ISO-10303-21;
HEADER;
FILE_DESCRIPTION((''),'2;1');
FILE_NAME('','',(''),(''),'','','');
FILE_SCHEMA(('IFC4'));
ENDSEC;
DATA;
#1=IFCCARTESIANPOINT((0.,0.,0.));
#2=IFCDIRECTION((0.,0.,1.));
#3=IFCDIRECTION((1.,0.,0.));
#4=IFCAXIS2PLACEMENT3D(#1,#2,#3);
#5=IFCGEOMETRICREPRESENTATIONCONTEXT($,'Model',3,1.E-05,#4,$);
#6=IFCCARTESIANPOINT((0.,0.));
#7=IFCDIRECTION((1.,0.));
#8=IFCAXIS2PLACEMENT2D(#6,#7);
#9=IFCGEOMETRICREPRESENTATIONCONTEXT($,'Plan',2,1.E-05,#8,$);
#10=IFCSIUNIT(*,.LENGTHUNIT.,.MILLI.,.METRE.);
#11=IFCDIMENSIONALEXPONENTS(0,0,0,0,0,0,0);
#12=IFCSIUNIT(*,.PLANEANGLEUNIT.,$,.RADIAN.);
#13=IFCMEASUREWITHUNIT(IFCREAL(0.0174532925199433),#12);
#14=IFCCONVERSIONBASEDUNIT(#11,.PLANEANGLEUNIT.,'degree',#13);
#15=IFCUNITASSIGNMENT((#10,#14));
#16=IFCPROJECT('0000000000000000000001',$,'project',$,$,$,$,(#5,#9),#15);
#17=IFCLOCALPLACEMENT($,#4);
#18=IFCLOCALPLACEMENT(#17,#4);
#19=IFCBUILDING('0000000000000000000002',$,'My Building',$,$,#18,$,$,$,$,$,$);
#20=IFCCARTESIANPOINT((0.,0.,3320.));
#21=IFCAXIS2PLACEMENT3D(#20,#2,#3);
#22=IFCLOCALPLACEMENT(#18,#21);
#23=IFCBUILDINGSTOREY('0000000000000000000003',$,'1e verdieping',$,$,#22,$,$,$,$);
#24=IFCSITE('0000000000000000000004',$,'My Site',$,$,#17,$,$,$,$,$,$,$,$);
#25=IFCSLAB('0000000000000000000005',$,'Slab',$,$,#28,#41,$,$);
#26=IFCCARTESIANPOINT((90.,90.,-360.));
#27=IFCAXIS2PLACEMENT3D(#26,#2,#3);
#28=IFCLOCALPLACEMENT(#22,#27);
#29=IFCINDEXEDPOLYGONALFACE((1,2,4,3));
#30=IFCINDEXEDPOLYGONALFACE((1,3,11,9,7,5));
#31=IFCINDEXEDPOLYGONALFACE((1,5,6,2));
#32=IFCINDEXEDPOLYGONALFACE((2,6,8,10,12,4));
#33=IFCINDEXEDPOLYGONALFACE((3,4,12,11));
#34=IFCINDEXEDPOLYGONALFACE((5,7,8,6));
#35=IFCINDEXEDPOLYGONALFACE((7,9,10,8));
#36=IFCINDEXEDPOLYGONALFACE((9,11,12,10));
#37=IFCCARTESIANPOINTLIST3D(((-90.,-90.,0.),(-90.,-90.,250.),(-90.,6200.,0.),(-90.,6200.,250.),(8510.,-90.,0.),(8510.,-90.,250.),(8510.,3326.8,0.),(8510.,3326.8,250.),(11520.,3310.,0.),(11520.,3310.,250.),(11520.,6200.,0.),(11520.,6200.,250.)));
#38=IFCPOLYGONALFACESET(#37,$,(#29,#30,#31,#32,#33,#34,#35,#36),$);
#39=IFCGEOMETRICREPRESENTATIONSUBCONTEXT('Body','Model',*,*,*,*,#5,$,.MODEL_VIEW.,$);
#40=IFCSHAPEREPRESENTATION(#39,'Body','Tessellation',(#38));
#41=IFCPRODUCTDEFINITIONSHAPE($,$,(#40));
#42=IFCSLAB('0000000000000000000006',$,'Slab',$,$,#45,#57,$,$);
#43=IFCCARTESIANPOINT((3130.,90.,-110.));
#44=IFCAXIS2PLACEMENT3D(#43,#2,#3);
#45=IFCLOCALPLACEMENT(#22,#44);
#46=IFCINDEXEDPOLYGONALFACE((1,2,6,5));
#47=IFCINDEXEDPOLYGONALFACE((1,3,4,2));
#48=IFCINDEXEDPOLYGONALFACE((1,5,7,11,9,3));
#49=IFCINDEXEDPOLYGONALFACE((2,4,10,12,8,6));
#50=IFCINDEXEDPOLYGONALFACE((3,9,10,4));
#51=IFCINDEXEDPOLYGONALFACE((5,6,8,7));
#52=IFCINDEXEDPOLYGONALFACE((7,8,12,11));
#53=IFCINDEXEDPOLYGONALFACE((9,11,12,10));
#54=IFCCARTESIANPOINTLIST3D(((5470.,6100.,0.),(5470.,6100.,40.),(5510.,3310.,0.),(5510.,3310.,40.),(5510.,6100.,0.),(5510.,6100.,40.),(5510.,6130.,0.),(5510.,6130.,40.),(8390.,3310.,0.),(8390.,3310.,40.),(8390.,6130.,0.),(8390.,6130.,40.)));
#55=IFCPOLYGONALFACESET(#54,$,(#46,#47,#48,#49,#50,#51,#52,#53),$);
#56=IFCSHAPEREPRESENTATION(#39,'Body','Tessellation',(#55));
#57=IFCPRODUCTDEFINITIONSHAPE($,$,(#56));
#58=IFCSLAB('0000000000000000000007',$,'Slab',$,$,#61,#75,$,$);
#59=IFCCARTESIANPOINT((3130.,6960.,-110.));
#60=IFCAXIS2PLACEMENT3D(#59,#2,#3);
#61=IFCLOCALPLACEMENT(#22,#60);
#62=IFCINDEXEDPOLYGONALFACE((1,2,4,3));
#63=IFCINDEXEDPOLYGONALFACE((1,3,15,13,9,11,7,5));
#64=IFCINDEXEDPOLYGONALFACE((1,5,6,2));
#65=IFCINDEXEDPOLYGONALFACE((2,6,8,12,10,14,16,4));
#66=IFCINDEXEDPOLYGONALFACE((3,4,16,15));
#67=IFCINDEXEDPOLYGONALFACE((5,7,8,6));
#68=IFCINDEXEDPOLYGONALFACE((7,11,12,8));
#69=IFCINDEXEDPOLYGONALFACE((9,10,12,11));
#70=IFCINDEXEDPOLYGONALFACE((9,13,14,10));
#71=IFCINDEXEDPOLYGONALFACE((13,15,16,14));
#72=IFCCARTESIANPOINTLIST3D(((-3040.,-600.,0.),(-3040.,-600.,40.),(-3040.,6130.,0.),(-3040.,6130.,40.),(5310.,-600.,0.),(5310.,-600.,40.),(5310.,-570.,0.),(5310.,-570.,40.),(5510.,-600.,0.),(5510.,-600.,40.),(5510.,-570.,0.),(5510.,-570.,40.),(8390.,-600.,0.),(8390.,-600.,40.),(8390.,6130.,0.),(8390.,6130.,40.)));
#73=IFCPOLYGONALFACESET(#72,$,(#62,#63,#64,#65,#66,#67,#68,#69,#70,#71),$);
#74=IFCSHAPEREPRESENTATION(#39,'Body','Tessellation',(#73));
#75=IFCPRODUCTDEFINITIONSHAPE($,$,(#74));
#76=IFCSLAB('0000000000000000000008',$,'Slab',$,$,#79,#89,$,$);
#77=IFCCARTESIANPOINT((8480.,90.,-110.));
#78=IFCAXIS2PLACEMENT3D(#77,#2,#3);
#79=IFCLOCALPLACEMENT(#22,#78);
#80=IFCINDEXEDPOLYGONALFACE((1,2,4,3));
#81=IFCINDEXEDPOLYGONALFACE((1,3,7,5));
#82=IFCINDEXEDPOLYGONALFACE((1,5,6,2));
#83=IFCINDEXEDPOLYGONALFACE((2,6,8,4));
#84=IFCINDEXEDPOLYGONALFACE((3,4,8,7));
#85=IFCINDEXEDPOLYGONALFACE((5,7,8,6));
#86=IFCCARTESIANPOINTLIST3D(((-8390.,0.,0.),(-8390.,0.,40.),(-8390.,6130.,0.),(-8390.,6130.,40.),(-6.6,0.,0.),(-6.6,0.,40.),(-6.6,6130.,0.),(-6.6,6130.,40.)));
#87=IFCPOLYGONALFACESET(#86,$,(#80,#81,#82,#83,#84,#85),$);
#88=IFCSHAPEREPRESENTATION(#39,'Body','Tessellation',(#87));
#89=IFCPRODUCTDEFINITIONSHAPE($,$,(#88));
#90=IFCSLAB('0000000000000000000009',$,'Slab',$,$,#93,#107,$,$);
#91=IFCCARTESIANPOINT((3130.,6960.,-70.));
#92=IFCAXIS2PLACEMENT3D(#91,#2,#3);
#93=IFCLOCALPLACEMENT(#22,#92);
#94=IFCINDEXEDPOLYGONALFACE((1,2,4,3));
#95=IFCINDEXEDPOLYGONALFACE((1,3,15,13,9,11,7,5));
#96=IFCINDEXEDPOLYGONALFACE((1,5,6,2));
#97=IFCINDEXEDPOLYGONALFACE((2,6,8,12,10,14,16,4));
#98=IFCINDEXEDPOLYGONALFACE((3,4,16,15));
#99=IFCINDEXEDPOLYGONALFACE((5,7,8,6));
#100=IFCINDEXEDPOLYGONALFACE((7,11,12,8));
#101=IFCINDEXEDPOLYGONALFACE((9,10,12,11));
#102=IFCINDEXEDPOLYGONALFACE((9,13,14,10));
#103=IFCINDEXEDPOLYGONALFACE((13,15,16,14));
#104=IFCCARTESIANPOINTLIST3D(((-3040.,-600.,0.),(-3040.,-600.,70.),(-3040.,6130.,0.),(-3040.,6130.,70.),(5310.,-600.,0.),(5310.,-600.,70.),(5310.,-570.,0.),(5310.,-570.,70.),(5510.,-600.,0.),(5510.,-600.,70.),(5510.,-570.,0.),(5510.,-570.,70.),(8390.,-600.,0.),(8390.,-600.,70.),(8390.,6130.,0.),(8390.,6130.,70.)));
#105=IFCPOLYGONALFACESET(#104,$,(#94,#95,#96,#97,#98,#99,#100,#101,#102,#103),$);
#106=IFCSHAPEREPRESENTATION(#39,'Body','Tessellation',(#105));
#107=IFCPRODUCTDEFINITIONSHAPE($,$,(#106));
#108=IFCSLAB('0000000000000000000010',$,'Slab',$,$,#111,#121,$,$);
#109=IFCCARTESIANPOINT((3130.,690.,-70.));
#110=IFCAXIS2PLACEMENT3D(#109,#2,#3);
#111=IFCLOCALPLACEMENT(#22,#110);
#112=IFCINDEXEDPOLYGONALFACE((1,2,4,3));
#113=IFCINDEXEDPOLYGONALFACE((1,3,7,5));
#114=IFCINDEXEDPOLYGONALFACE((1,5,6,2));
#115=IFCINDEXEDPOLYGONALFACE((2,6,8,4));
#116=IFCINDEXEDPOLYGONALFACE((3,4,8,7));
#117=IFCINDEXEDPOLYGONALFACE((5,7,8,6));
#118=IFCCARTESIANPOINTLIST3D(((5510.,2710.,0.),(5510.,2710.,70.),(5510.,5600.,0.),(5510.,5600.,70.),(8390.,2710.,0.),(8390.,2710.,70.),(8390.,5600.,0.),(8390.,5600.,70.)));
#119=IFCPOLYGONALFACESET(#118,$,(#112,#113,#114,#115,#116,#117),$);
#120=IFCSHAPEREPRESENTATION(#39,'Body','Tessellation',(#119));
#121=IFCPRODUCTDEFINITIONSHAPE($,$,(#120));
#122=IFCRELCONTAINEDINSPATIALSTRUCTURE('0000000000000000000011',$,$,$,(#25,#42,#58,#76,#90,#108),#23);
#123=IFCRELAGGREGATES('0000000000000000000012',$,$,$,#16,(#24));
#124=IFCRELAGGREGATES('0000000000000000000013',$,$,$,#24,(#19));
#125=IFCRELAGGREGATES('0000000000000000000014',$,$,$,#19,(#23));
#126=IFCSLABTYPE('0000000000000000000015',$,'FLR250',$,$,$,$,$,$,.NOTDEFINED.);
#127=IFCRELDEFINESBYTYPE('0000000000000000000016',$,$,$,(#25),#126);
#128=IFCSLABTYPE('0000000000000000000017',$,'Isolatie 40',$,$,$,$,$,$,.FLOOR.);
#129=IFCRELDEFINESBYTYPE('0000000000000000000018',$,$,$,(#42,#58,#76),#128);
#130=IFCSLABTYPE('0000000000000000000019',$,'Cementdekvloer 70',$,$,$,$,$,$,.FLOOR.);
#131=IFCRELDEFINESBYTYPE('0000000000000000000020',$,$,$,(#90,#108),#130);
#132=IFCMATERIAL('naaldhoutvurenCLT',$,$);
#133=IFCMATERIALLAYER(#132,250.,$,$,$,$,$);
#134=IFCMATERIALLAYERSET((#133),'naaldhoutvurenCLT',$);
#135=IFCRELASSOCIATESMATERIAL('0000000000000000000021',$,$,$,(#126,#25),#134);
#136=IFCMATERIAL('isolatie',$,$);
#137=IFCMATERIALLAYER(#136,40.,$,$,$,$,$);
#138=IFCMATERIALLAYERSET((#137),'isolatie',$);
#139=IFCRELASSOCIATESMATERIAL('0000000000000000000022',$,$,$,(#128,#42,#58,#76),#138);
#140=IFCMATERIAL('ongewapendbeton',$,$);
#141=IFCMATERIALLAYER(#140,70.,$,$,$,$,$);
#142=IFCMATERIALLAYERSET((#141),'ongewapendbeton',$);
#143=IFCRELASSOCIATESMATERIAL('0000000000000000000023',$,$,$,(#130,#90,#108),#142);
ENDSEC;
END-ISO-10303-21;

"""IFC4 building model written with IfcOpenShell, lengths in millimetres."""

from ifc_helpers import new_model, entity, si_unit, converted_unit, frame, origin_with_axes, origin_2d_with_axis, place, context, subcontext, project, spatial, line, indexed_curve, outline, extrude, material, layer, layer_set, layer_usage, type_object, element, save


model = new_model("IFC4")

# Units and contexts
model_context = context("Model", 3, precision=1e-05, world=origin_with_axes())
plan_context = context("Plan", 2, precision=1e-05, world=origin_2d_with_axis())
body_context = subcontext(model_context, "Body", "Model", "MODEL_VIEW")
ifc_project = project(units=[si_unit("LENGTHUNIT", "METRE", prefix="MILLI"), converted_unit("PLANEANGLEUNIT", "degree", entity("IfcReal", 0.0174532925199433), si_unit("PLANEANGLEUNIT", "RADIAN"), dimensions=[0, 0, 0, 0, 0, 0, 0])], contexts=[model_context, plan_context])

# Site, building, storey
site_placement = place(None, origin_with_axes())
site = spatial("IfcSite", under=ifc_project, at=site_placement, Name="My Site")
building_placement = place(site_placement, origin_with_axes())
building = spatial("IfcBuilding", under=site, at=building_placement, Name="My Building")
storey_placement = place(building_placement, frame((0.0, 0.0, 3320.0), z_axis=(0.0, 0.0, 1.0), x_axis=(1.0, 0.0, 0.0)))
storey = spatial("IfcBuildingStorey", under=building, at=storey_placement, Name="1e verdieping")

# Shared definitions
ifc_material_1 = material(Name="naaldhoutvurenCLT")

# Slabs
ifc_layer_1 = layer(ifc_material_1, 250.0)
ifc_layer_set_1 = layer_set([ifc_layer_1], Name="naaldhoutvurenCLT")
ifc_layer_usage_1 = layer_usage(ifc_layer_set_1, "AXIS3", "POSITIVE", 0.0)
slab_type_1 = type_object("IfcSlabType", Name="FLR250", PredefinedType="NOTDEFINED", material=ifc_layer_set_1)
slab_1_placement = place(storey_placement, frame((90.0, 90.0, -360.0), z_axis=(0.0, 0.0, 1.0), x_axis=(1.0, 0.0, 0.0)))
element("IfcSlab", 1, at=slab_1_placement, inside=storey, type_object=slab_type_1, material=ifc_layer_usage_1, Name="Slab", context=body_context, shape_type="SweptSolid", body=[
    extrude(outline(indexed_curve([(8510.0, 3326.8), (11520.0, 3310.0), (11520.0, 6200.0), (-90.0, 6200.0), (-90.0, -90.0), (8510.0, -90.0)], segments=[line(2, 1), line(1, 6), line(6, 5), line(5, 4), line(4, 3), line(3, 2)], self_intersect=False)), None, (0.0, 0.0, 1.0), 250.0),
])
ifc_material_2 = material(Name="isolatie")
ifc_layer_2 = layer(ifc_material_2, 40.0)
ifc_layer_set_2 = layer_set([ifc_layer_2], Name="isolatie")
slab_type_2 = type_object("IfcSlabType", Name="Isolatie 40", PredefinedType="FLOOR", material=ifc_layer_set_2)
ifc_layer_usage_2 = layer_usage(ifc_layer_set_2, "AXIS3", "POSITIVE", 0.0)
slab_2_placement = place(storey_placement, frame((3130.0, 90.0, -110.0), z_axis=(0.0, 0.0, 1.0), x_axis=(1.0, 0.0, 0.0)))
element("IfcSlab", 2, at=slab_2_placement, inside=storey, type_object=slab_type_2, material=ifc_layer_usage_2, Name="Slab", context=body_context, shape_type="SweptSolid", body=[
    extrude(outline(indexed_curve([(5510.0, 3310.0), (8390.0, 3310.0), (8390.0, 6130.0), (5510.0, 6130.0), (5510.0, 6100.0), (5470.0, 6100.0)], segments=[line(1, 6), line(6, 5), line(5, 4), line(4, 3), line(3, 2), line(2, 1)], self_intersect=False)), None, (0.0, 0.0, 1.0), 40.0),
])
ifc_layer_usage_3 = layer_usage(ifc_layer_set_2, "AXIS3", "POSITIVE", 0.0)
slab_3_placement = place(storey_placement, frame((3130.0, 6960.0, -110.0), z_axis=(0.0, 0.0, 1.0), x_axis=(1.0, 0.0, 0.0)))
element("IfcSlab", 3, at=slab_3_placement, inside=storey, type_object=slab_type_2, material=ifc_layer_usage_3, Name="Slab", context=body_context, shape_type="SweptSolid", body=[
    extrude(outline(indexed_curve([(5510.0, -600.0), (8390.0, -600.0), (5510.0, -570.0), (8390.0, 6130.0), (5310.0, -570.0), (5310.0, -600.0), (-3040.0, -600.0), (-3040.0, 6130.0)], segments=[line(5, 3), line(3, 1), line(1, 2), line(2, 4), line(4, 8), line(8, 7), line(7, 6), line(6, 5)], self_intersect=False)), None, (0.0, 0.0, 1.0), 40.0),
])
ifc_layer_usage_4 = layer_usage(ifc_layer_set_2, "AXIS3", "POSITIVE", 0.0)
slab_4_placement = place(storey_placement, frame((8480.0, 90.0, -110.0), z_axis=(0.0, 0.0, 1.0), x_axis=(1.0, 0.0, 0.0)))
element("IfcSlab", 4, at=slab_4_placement, inside=storey, type_object=slab_type_2, material=ifc_layer_usage_4, Name="Slab", context=body_context, shape_type="SweptSolid", body=[
    extrude(outline(indexed_curve([(-8390.0, 0.0), (-6.6, 0.0), (-6.6, 6130.0), (-8390.0, 6130.0)], segments=[line(4, 1), line(1, 2), line(2, 3), line(3, 4)], self_intersect=False)), None, (0.0, 0.0, 1.0), 40.0),
])
ifc_material_3 = material(Name="ongewapendbeton")
ifc_layer_3 = layer(ifc_material_3, 70.0)
ifc_layer_set_3 = layer_set([ifc_layer_3], Name="ongewapendbeton")
slab_type_3 = type_object("IfcSlabType", Name="Cementdekvloer 70", PredefinedType="FLOOR", material=ifc_layer_set_3)
ifc_layer_usage_5 = layer_usage(ifc_layer_set_3, "AXIS3", "POSITIVE", 0.0)
slab_5_placement = place(storey_placement, frame((3130.0, 6960.0, -70.0), z_axis=(0.0, 0.0, 1.0), x_axis=(1.0, 0.0, 0.0)))
element("IfcSlab", 5, at=slab_5_placement, inside=storey, type_object=slab_type_3, material=ifc_layer_usage_5, Name="Slab", context=body_context, shape_type="SweptSolid", body=[
    extrude(outline(indexed_curve([(-3040.0, -600.0), (5310.0, -600.0), (5310.0, -570.0), (5510.0, -570.0), (5510.0, -600.0), (8390.0, -600.0), (8390.0, 6130.0), (-3040.0, 6130.0)], segments=[line(1, 8), line(8, 7), line(7, 6), line(6, 5), line(5, 4), line(4, 3), line(3, 2), line(2, 1)], self_intersect=False)), None, (0.0, 0.0, 1.0), 70.0),
])
ifc_layer_usage_6 = layer_usage(ifc_layer_set_3, "AXIS3", "POSITIVE", 0.0)
slab_6_placement = place(storey_placement, frame((3130.0, 690.0, -70.0), z_axis=(0.0, 0.0, 1.0), x_axis=(1.0, 0.0, 0.0)))
element("IfcSlab", 6, at=slab_6_placement, inside=storey, type_object=slab_type_3, material=ifc_layer_usage_6, Name="Slab", context=body_context, shape_type="SweptSolid", body=[
    extrude(outline(indexed_curve([(8390.0, 5600.0), (5510.0, 5600.0), (5510.0, 2710.0), (8390.0, 2710.0)], segments=[line(4, 1), line(1, 2), line(2, 3), line(3, 4)], self_intersect=False)), None, (0.0, 0.0, 1.0), 70.0),
])

save(model, "model.ifc")
